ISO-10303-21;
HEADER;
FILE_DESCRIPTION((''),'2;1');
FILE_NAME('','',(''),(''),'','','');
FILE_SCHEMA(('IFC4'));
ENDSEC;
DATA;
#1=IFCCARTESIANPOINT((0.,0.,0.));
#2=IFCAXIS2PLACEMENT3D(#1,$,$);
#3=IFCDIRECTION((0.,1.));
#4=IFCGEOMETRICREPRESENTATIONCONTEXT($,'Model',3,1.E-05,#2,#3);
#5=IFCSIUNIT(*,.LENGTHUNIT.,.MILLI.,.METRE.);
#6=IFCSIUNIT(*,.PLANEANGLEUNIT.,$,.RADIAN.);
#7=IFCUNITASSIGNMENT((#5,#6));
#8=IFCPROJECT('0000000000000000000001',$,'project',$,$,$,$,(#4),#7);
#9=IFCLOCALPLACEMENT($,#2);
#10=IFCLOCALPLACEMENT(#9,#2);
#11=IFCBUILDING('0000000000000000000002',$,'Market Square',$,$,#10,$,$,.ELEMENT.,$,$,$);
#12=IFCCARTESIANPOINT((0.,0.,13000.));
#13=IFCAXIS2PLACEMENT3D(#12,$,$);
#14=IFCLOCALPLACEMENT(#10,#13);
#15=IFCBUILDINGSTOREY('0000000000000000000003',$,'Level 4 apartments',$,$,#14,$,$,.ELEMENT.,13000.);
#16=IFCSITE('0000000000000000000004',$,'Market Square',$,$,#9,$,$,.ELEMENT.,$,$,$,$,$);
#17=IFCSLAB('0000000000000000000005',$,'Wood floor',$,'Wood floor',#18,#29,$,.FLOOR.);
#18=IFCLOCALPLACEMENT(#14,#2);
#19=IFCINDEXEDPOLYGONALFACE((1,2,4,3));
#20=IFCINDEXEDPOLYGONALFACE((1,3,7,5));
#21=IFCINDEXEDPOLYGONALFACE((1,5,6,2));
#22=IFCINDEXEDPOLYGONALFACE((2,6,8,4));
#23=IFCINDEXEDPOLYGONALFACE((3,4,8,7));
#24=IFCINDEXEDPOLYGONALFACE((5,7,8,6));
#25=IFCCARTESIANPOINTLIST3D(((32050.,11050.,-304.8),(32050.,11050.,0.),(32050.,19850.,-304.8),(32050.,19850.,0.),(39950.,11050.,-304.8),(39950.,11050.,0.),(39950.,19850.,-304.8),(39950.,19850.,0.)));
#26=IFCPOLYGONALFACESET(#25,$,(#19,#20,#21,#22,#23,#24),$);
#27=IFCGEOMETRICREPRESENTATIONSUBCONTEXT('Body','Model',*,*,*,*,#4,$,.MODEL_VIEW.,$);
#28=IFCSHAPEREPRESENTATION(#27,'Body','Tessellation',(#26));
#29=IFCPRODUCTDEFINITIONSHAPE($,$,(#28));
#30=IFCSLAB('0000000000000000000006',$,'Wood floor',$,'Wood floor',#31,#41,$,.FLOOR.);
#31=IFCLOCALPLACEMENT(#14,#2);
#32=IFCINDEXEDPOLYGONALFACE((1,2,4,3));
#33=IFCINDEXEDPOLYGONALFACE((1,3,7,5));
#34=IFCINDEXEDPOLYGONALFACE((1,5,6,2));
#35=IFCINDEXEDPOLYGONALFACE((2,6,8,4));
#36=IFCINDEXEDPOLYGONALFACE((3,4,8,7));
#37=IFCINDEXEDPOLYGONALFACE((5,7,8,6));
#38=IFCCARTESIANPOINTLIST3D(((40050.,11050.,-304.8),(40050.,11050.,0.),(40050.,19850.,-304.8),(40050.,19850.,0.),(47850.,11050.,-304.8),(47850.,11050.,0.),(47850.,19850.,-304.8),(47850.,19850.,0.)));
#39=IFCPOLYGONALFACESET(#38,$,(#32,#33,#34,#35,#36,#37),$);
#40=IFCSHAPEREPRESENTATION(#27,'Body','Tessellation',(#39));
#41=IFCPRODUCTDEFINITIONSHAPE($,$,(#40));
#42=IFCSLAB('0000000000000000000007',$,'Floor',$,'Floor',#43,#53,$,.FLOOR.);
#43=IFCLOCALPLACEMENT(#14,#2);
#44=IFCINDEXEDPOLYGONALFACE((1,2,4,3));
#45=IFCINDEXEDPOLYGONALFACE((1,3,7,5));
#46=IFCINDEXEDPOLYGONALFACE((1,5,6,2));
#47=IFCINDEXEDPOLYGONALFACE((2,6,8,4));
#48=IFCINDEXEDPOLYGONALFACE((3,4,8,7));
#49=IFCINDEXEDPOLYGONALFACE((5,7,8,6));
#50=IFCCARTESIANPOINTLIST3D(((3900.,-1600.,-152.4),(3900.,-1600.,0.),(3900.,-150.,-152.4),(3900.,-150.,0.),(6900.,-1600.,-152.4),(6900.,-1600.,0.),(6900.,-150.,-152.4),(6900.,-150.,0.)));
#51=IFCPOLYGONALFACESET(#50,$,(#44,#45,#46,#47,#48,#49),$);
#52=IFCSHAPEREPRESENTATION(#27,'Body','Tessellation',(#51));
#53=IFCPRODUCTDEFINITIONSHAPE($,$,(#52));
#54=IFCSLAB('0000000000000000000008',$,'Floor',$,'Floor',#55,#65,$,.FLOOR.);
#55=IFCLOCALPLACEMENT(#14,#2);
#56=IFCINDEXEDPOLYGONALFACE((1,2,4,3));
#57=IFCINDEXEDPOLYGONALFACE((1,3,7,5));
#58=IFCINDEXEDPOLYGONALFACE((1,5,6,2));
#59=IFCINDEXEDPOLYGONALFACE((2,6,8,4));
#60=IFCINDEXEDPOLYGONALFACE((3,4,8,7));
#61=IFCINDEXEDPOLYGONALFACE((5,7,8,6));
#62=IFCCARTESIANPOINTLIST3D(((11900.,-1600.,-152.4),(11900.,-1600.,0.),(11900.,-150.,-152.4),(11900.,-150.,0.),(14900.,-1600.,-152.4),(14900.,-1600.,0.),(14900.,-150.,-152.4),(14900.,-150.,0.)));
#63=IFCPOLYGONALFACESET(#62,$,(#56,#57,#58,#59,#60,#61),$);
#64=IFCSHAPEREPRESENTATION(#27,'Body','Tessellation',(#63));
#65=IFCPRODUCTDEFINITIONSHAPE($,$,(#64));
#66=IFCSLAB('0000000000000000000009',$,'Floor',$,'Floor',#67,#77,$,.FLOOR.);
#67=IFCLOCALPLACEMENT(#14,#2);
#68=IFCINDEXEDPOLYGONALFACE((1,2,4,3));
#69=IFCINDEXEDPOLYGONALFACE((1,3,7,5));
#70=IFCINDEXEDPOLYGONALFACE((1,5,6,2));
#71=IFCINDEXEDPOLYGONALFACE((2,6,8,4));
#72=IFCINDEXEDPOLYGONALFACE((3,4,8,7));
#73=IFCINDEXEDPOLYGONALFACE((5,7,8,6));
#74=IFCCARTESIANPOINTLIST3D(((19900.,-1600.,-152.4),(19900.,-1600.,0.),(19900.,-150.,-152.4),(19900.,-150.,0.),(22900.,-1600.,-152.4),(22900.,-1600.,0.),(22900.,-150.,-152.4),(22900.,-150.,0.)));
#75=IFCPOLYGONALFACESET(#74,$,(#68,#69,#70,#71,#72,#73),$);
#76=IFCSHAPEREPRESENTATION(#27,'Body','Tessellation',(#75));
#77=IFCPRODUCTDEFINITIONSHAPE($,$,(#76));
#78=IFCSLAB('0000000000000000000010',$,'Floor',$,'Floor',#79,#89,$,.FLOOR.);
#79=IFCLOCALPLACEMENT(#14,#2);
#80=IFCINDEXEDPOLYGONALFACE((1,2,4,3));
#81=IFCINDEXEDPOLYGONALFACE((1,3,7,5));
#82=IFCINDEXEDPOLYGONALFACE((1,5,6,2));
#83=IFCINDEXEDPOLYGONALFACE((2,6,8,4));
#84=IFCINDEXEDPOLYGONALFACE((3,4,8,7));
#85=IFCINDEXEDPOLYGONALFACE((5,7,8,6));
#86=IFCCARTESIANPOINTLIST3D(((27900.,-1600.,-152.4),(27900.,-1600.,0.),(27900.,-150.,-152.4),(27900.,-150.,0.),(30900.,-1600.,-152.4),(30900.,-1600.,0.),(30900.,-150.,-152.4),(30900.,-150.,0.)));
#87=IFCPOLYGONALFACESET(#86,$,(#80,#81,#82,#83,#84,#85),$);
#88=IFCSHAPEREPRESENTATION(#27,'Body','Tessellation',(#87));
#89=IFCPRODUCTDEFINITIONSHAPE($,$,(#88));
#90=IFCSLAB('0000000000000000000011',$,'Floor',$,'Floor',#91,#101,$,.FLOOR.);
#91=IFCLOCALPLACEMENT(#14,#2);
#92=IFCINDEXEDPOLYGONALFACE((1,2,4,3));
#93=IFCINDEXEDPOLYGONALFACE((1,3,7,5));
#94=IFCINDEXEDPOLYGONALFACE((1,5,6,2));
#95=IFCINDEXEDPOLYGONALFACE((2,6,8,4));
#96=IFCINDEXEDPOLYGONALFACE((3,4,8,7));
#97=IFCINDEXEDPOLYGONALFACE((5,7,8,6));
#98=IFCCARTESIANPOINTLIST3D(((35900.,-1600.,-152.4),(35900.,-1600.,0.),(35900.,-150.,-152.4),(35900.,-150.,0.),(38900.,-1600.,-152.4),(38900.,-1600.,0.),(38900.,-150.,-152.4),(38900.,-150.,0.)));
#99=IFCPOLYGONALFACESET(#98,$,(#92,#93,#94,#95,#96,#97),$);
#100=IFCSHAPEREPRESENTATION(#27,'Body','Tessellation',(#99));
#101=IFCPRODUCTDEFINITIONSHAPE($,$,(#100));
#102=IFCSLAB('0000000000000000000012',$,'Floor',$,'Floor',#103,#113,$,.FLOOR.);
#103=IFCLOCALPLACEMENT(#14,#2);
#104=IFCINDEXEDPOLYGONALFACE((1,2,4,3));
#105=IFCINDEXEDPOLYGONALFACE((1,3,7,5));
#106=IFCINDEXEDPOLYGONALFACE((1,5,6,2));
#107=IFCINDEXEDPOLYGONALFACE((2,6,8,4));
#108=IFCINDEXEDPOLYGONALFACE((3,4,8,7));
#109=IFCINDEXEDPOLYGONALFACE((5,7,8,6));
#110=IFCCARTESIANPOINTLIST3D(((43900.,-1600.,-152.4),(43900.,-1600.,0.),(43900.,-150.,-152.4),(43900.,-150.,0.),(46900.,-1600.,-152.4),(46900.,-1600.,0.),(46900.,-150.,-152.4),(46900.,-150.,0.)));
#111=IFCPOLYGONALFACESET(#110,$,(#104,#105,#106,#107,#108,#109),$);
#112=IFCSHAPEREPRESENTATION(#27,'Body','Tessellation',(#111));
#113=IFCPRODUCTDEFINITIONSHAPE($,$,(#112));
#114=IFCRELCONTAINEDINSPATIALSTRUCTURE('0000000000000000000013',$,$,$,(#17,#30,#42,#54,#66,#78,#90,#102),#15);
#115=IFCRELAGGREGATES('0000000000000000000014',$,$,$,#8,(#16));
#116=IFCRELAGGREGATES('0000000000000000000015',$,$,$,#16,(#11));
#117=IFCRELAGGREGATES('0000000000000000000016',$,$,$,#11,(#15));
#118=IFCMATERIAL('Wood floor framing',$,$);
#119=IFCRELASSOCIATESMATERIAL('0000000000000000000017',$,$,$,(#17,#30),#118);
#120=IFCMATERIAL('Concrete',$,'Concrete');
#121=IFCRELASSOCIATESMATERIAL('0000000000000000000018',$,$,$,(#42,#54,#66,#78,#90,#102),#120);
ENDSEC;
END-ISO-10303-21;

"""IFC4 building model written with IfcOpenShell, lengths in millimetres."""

from ifc_helpers import new_model, si_unit, direction, frame, origin, origin_with_axes, place, context, subcontext, project, spatial, polyline, outline, extrude, material, element, save


model = new_model("IFC4")

# Units and contexts
model_context = context("Model", 3, precision=1e-05, world=origin(), true_north=direction((0.0, 1.0)))
body_context = subcontext(model_context, "Body", "Model", "MODEL_VIEW")
ifc_project = project(units=[si_unit("LENGTHUNIT", "METRE", prefix="MILLI"), si_unit("PLANEANGLEUNIT", "RADIAN")], contexts=[model_context])

# Site, building, storey
site_placement = place(None, origin())
site = spatial("IfcSite", under=ifc_project, at=site_placement, Name="Market Square", CompositionType="ELEMENT")
building_placement = place(site_placement, origin())
building = spatial("IfcBuilding", under=site, at=building_placement, Name="Market Square", CompositionType="ELEMENT")
storey_placement = place(building_placement, frame((0.0, 0.0, 13000.0)))
storey = spatial("IfcBuildingStorey", under=building, at=storey_placement, Name="Level 4 apartments", CompositionType="ELEMENT", Elevation=13000.0)

# Slabs
ifc_material_1 = material(Name="Wood floor framing")
slab_1_placement = place(storey_placement, origin_with_axes())
element("IfcSlab", 1, at=slab_1_placement, inside=storey, material=ifc_material_1, Name="Wood floor", ObjectType="Wood floor", PredefinedType="FLOOR", context=body_context, shape_type="SweptSolid", body=[
    extrude(outline(polyline([(39950.0, 19850.0), (32050.0, 19850.0), (32050.0, 11050.0), (39950.0, 11050.0), (39950.0, 19850.0)])), frame((0.0, 0.0, -304.8)), (0.0, 0.0, 1.0), 304.8),
])
slab_2_placement = place(storey_placement, origin_with_axes())
element("IfcSlab", 2, at=slab_2_placement, inside=storey, material=ifc_material_1, Name="Wood floor", ObjectType="Wood floor", PredefinedType="FLOOR", context=body_context, shape_type="SweptSolid", body=[
    extrude(outline(polyline([(47850.0, 11050.0), (47850.0, 19850.0), (40050.0, 19850.0), (40050.0, 11050.0), (47850.0, 11050.0)])), frame((0.0, 0.0, -304.8)), (0.0, 0.0, 1.0), 304.8),
])
ifc_material_2 = material(Name="Concrete", Category="Concrete")
slab_3_placement = place(storey_placement, origin_with_axes())
element("IfcSlab", 3, at=slab_3_placement, inside=storey, material=ifc_material_2, Name="Floor", ObjectType="Floor", PredefinedType="FLOOR", context=body_context, shape_type="SweptSolid", body=[
    extrude(outline(polyline([(3900.0, -1600.0), (6900.0, -1600.0), (6900.0, -150.0), (3900.0, -150.0), (3900.0, -1600.0)])), frame((0.0, 0.0, -152.4)), (0.0, 0.0, 1.0), 152.4),
])
slab_4_placement = place(storey_placement, origin_with_axes())
element("IfcSlab", 4, at=slab_4_placement, inside=storey, material=ifc_material_2, Name="Floor", ObjectType="Floor", PredefinedType="FLOOR", context=body_context, shape_type="SweptSolid", body=[
    extrude(outline(polyline([(11900.0, -1600.0), (14900.0, -1600.0), (14900.0, -150.0), (11900.0, -150.0), (11900.0, -1600.0)])), frame((0.0, 0.0, -152.4)), (0.0, 0.0, 1.0), 152.4),
])
slab_5_placement = place(storey_placement, origin_with_axes())
element("IfcSlab", 5, at=slab_5_placement, inside=storey, material=ifc_material_2, Name="Floor", ObjectType="Floor", PredefinedType="FLOOR", context=body_context, shape_type="SweptSolid", body=[
    extrude(outline(polyline([(19900.0, -1600.0), (22900.0, -1600.0), (22900.0, -150.0), (19900.0, -150.0), (19900.0, -1600.0)])), frame((0.0, 0.0, -152.4)), (0.0, 0.0, 1.0), 152.4),
])
slab_6_placement = place(storey_placement, origin_with_axes())
element("IfcSlab", 6, at=slab_6_placement, inside=storey, material=ifc_material_2, Name="Floor", ObjectType="Floor", PredefinedType="FLOOR", context=body_context, shape_type="SweptSolid", body=[
    extrude(outline(polyline([(27900.0, -1600.0), (30900.0, -1600.0), (30900.0, -150.0), (27900.0, -150.0), (27900.0, -1600.0)])), frame((0.0, 0.0, -152.4)), (0.0, 0.0, 1.0), 152.4),
])
slab_7_placement = place(storey_placement, origin_with_axes())
element("IfcSlab", 7, at=slab_7_placement, inside=storey, material=ifc_material_2, Name="Floor", ObjectType="Floor", PredefinedType="FLOOR", context=body_context, shape_type="SweptSolid", body=[
    extrude(outline(polyline([(35900.0, -1600.0), (38900.0, -1600.0), (38900.0, -150.0), (35900.0, -150.0), (35900.0, -1600.0)])), frame((0.0, 0.0, -152.4)), (0.0, 0.0, 1.0), 152.4),
])
slab_8_placement = place(storey_placement, origin_with_axes())
element("IfcSlab", 8, at=slab_8_placement, inside=storey, material=ifc_material_2, Name="Floor", ObjectType="Floor", PredefinedType="FLOOR", context=body_context, shape_type="SweptSolid", body=[
    extrude(outline(polyline([(43900.0, -1600.0), (46900.0, -1600.0), (46900.0, -150.0), (43900.0, -150.0), (43900.0, -1600.0)])), frame((0.0, 0.0, -152.4)), (0.0, 0.0, 1.0), 152.4),
])

save(model, "model.ifc")
